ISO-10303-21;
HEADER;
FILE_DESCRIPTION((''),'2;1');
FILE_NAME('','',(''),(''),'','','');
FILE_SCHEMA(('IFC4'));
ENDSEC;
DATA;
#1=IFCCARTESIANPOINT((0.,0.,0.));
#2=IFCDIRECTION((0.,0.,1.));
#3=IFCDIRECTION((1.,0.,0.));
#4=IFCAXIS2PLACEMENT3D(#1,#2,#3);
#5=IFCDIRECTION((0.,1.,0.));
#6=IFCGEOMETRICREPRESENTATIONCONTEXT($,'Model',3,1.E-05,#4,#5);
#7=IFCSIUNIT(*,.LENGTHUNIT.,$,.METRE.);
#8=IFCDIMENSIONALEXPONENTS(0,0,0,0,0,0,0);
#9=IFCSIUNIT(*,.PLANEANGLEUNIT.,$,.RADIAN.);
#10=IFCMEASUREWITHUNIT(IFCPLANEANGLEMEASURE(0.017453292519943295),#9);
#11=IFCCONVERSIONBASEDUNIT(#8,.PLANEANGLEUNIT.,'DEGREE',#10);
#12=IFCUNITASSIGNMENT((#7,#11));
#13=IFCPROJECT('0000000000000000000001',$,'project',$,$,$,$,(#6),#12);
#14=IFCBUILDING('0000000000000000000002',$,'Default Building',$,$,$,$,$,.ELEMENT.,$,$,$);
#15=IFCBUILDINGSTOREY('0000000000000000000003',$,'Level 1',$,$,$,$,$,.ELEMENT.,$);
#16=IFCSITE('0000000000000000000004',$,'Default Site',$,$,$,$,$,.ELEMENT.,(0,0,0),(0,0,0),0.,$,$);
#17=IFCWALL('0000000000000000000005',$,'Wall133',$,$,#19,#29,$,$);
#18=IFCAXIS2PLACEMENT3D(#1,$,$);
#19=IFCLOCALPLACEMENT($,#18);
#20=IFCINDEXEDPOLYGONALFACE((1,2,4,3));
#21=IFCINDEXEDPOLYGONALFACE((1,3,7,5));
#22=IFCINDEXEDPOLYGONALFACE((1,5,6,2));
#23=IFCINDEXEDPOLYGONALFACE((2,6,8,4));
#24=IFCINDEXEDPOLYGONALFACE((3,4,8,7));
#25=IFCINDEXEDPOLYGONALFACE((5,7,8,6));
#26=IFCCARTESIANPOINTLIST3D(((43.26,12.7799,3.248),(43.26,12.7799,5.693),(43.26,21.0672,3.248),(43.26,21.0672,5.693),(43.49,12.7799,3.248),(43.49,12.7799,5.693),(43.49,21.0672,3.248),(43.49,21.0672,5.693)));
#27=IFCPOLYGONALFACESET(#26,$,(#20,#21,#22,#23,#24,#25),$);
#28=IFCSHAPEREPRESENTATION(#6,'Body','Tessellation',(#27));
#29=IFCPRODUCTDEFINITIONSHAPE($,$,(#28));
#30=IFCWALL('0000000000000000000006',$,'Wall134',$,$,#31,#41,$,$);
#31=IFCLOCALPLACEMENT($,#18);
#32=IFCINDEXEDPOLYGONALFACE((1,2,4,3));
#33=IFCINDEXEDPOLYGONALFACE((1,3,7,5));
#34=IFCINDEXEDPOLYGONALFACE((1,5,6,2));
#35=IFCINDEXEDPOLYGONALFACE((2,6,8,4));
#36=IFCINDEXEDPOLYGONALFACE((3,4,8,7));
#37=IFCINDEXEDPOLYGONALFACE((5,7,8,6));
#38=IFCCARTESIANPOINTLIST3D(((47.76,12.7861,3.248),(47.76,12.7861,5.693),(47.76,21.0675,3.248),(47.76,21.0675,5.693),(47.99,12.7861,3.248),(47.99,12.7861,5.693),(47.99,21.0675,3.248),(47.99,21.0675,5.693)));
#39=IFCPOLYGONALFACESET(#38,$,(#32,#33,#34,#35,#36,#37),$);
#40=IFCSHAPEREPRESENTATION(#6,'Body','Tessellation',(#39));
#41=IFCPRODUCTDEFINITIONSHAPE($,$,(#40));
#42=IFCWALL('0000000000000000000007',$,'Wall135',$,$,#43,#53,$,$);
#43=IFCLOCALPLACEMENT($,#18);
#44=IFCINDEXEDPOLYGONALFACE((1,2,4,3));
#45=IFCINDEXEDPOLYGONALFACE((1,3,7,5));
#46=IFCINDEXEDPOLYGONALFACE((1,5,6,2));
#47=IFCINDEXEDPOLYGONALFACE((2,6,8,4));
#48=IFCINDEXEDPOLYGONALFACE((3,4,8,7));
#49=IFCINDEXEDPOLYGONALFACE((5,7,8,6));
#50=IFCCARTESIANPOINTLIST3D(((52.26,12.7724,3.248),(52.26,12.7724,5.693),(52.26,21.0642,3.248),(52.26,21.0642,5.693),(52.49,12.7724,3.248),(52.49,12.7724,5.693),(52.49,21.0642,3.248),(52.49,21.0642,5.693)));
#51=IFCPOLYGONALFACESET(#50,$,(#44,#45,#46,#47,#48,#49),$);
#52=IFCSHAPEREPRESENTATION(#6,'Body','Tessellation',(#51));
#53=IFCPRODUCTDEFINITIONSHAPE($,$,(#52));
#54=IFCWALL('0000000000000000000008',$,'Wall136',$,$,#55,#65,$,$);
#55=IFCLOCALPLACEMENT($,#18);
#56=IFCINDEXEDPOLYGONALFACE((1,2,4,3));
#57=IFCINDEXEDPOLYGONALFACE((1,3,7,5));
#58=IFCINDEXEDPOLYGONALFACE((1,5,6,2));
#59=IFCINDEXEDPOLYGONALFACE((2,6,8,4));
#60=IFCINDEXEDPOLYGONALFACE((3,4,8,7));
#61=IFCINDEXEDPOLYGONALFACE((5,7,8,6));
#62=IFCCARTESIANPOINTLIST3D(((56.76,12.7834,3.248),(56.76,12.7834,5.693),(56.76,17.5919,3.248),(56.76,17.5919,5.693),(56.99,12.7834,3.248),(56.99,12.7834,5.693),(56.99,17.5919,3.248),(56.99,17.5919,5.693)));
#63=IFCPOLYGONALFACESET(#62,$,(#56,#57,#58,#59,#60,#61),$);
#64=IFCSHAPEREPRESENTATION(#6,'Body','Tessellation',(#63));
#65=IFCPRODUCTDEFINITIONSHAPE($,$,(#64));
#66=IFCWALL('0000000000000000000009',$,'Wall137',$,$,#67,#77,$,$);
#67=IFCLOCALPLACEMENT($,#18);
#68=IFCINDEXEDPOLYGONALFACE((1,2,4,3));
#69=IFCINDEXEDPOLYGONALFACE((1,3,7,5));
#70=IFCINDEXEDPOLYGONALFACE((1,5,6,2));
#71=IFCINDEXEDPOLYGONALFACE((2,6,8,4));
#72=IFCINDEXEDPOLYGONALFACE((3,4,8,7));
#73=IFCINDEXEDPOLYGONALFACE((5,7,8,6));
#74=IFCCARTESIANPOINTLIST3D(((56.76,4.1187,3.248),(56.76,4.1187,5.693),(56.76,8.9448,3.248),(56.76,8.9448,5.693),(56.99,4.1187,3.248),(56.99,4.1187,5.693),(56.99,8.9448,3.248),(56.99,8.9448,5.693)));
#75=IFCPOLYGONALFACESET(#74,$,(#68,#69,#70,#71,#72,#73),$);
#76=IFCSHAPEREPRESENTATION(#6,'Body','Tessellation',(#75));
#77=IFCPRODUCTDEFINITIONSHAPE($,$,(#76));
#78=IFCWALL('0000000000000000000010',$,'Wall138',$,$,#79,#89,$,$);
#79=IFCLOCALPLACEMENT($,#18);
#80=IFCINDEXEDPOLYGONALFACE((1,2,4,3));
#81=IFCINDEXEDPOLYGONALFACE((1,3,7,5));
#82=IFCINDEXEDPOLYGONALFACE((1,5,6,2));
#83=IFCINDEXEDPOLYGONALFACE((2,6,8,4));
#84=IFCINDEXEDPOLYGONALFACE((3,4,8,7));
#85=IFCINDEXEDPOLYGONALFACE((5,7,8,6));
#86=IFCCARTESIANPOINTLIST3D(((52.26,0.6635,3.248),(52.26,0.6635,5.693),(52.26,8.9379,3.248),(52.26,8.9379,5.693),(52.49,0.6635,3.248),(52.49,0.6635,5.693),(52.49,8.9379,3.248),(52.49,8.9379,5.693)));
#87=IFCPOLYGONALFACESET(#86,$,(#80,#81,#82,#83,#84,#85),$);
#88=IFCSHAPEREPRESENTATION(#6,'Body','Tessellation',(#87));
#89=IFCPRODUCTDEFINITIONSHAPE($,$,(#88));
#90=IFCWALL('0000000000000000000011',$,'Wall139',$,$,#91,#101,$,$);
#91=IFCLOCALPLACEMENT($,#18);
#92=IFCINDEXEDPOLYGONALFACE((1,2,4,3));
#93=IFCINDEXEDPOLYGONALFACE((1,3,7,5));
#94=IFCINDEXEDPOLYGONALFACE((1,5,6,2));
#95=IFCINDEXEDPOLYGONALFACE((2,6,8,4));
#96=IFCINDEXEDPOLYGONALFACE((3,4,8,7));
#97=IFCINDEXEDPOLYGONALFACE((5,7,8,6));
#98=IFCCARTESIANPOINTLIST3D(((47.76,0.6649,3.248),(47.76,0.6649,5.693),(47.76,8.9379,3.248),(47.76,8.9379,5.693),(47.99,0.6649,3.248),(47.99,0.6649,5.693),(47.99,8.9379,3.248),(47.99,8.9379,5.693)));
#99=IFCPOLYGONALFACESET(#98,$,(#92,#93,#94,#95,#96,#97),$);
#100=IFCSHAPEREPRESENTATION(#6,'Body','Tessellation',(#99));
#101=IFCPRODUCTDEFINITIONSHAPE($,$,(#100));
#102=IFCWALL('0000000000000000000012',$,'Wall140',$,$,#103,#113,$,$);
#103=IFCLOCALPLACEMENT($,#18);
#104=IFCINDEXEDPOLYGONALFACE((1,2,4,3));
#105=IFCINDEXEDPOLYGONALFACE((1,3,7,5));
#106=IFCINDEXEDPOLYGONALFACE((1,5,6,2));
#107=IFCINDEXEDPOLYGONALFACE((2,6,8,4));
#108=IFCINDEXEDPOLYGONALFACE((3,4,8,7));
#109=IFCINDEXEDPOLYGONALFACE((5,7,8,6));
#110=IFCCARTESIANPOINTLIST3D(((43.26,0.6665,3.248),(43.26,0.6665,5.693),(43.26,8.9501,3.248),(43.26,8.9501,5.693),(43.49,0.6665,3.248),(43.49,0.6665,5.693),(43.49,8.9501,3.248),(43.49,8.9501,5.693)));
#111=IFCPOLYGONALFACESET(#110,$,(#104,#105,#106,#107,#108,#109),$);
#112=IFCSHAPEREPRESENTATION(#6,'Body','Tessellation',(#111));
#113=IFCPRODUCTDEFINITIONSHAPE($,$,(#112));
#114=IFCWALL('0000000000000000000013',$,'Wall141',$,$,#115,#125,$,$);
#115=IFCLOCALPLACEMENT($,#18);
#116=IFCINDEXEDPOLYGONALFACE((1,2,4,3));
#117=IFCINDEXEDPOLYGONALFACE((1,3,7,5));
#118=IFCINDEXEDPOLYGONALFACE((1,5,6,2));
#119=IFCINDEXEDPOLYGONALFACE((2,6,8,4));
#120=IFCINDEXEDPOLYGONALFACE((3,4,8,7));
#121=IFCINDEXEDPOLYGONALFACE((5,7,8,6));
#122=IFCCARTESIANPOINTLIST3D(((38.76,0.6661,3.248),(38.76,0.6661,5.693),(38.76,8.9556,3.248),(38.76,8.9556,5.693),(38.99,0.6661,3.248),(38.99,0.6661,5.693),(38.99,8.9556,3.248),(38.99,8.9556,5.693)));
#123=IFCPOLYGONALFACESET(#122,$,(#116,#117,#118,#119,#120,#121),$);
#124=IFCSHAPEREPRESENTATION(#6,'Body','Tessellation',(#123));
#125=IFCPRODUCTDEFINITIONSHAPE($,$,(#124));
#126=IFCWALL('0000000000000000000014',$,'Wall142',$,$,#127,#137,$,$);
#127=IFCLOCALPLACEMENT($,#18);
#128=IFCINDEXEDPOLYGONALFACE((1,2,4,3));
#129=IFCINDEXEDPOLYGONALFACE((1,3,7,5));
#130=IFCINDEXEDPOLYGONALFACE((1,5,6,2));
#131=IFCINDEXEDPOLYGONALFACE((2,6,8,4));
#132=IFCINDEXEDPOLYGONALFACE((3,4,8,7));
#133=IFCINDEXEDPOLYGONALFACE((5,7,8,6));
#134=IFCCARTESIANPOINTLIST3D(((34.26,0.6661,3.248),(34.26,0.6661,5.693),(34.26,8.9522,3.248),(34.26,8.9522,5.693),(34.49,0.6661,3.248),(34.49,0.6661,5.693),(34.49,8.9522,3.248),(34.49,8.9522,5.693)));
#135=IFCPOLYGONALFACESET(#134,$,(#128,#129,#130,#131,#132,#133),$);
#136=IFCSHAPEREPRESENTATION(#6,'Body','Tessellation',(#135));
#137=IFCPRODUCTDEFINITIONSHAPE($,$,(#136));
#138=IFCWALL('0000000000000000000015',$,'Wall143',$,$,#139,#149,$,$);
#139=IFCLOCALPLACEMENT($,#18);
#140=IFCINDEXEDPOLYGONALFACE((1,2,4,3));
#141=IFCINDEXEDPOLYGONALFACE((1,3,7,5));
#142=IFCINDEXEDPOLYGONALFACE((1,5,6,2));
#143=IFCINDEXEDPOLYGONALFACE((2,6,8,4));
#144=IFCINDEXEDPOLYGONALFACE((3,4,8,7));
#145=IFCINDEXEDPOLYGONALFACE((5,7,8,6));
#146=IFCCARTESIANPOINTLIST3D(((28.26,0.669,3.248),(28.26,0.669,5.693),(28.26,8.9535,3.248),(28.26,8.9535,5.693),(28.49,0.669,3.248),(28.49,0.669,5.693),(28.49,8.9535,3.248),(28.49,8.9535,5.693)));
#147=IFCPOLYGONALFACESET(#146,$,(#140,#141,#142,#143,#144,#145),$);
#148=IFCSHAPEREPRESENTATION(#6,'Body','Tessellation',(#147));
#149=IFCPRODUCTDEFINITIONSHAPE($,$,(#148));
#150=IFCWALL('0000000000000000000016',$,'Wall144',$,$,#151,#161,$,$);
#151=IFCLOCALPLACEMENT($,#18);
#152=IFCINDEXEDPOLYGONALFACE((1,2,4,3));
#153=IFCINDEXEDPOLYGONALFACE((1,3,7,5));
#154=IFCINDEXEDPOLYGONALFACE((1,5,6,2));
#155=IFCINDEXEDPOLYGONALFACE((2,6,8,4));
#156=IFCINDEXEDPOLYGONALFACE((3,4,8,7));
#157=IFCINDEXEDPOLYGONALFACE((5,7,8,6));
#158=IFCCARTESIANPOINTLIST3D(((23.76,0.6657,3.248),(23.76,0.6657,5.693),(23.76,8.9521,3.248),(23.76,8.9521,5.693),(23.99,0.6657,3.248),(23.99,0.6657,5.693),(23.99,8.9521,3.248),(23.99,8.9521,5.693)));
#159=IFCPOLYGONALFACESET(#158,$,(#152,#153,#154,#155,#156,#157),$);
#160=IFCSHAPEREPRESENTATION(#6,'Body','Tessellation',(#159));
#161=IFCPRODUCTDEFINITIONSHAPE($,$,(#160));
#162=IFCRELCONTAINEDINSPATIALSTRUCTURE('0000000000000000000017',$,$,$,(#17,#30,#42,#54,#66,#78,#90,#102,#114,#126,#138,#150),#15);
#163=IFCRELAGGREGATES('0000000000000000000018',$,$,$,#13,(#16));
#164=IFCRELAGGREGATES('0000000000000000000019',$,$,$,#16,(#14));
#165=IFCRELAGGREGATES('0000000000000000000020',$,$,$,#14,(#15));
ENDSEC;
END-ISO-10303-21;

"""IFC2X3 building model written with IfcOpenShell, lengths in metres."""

from ifc_helpers import new_model, entity, si_unit, converted_unit, direction, frame, frame_2d, origin_with_axes, place, context, project, spatial, rectangle, extrude, element, save


model = new_model("IFC2X3")

# Units and contexts
model_context = context("Model", 3, precision=1e-05, world=origin_with_axes(), true_north=direction((0.0, 1.0, 0.0)))
ifc_project = project(units=[si_unit("LENGTHUNIT", "METRE"), converted_unit("PLANEANGLEUNIT", "DEGREE", entity("IfcPlaneAngleMeasure", 0.017453292519943295), si_unit("PLANEANGLEUNIT", "RADIAN"), dimensions=[0, 0, 0, 0, 0, 0, 0])], contexts=[model_context])

# Site, building, storey
site = spatial("IfcSite", under=ifc_project, Name="Default Site", CompositionType="ELEMENT", RefLatitude=(0, 0, 0), RefLongitude=(0, 0, 0), RefElevation=0.0)
building = spatial("IfcBuilding", under=site, Name="Default Building", CompositionType="ELEMENT")
storey = spatial("IfcBuildingStorey", under=building, Name="Level 1", CompositionType="ELEMENT")

# Shared definitions
placement = place(None, origin_with_axes())

# Walls
element("IfcWall", 1, at=placement, inside=storey, Name="Wall133", context=model_context, shape_type="SweptSolid", body=[
    extrude(rectangle(XDim=8.2873, YDim=0.23, at=frame_2d((0.0, 0.0), x_axis=(0.0, 1.0, 0.0))), frame((43.375, 16.9235, 3.248), z_axis=(0.0, 0.0, 1.0), x_axis=(1.0, 0.0, 0.0)), (0.0, 0.0, 1.0), 2.445),
])
element("IfcWall", 2, at=placement, inside=storey, Name="Wall134", context=model_context, shape_type="SweptSolid", body=[
    extrude(rectangle(XDim=8.2814, YDim=0.23, at=frame_2d((0.0, 0.0), x_axis=(0.0, -1.0, 0.0))), frame((47.875, 16.9268, 3.248), z_axis=(0.0, 0.0, 1.0), x_axis=(1.0, 0.0, 0.0)), (0.0, 0.0, 1.0), 2.445),
])
element("IfcWall", 3, at=placement, inside=storey, Name="Wall135", context=model_context, shape_type="SweptSolid", body=[
    extrude(rectangle(XDim=8.2918, YDim=0.23, at=frame_2d((0.0, 0.0), x_axis=(0.0, -1.0, 0.0))), frame((52.375, 16.9183, 3.248), z_axis=(0.0, 0.0, 1.0), x_axis=(1.0, 0.0, 0.0)), (0.0, 0.0, 1.0), 2.445),
])
element("IfcWall", 4, at=placement, inside=storey, Name="Wall136", context=model_context, shape_type="SweptSolid", body=[
    extrude(rectangle(XDim=4.8085, YDim=0.23, at=frame_2d((0.0, 0.0), x_axis=(0.0, 1.0, 0.0))), frame((56.875, 15.1877, 3.248), z_axis=(0.0, 0.0, 1.0), x_axis=(1.0, 0.0, 0.0)), (0.0, 0.0, 1.0), 2.445),
])
element("IfcWall", 5, at=placement, inside=storey, Name="Wall137", context=model_context, shape_type="SweptSolid", body=[
    extrude(rectangle(XDim=4.8261, YDim=0.23, at=frame_2d((0.0, 0.0), x_axis=(0.0, -1.0, 0.0))), frame((56.875, 6.5318, 3.248), z_axis=(0.0, 0.0, 1.0), x_axis=(1.0, 0.0, 0.0)), (0.0, 0.0, 1.0), 2.445),
])
element("IfcWall", 6, at=placement, inside=storey, Name="Wall138", context=model_context, shape_type="SweptSolid", body=[
    extrude(rectangle(XDim=8.2744, YDim=0.23, at=frame_2d((0.0, 0.0), x_axis=(0.0, 1.0, 0.0))), frame((52.375, 4.8007, 3.248), z_axis=(0.0, 0.0, 1.0), x_axis=(1.0, 0.0, 0.0)), (0.0, 0.0, 1.0), 2.445),
])
element("IfcWall", 7, at=placement, inside=storey, Name="Wall139", context=model_context, shape_type="SweptSolid", body=[
    extrude(rectangle(XDim=8.273, YDim=0.23, at=frame_2d((0.0, 0.0), x_axis=(0.0, -1.0, 0.0))), frame((47.875, 4.8014, 3.248), z_axis=(0.0, 0.0, 1.0), x_axis=(1.0, 0.0, 0.0)), (0.0, 0.0, 1.0), 2.445),
])
element("IfcWall", 8, at=placement, inside=storey, Name="Wall140", context=model_context, shape_type="SweptSolid", body=[
    extrude(rectangle(XDim=8.2836, YDim=0.23, at=frame_2d((0.0, 0.0), x_axis=(0.0, 1.0, 0.0))), frame((43.375, 4.8083, 3.248), z_axis=(0.0, 0.0, 1.0), x_axis=(1.0, 0.0, 0.0)), (0.0, 0.0, 1.0), 2.445),
])
element("IfcWall", 9, at=placement, inside=storey, Name="Wall141", context=model_context, shape_type="SweptSolid", body=[
    extrude(rectangle(XDim=8.2895, YDim=0.23, at=frame_2d((0.0, 0.0), x_axis=(0.0, -1.0, 0.0))), frame((38.875, 4.8109, 3.248), z_axis=(0.0, 0.0, 1.0), x_axis=(1.0, 0.0, 0.0)), (0.0, 0.0, 1.0), 2.445),
])
element("IfcWall", 10, at=placement, inside=storey, Name="Wall142", context=model_context, shape_type="SweptSolid", body=[
    extrude(rectangle(XDim=8.2861, YDim=0.23, at=frame_2d((0.0, 0.0), x_axis=(0.0, -1.0, 0.0))), frame((34.375, 4.8092, 3.248), z_axis=(0.0, 0.0, 1.0), x_axis=(1.0, 0.0, 0.0)), (0.0, 0.0, 1.0), 2.445),
])
element("IfcWall", 11, at=placement, inside=storey, Name="Wall143", context=model_context, shape_type="SweptSolid", body=[
    extrude(rectangle(XDim=8.2845, YDim=0.23, at=frame_2d((0.0, 0.0), x_axis=(0.0, 1.0, 0.0))), frame((28.375, 4.8113, 3.248), z_axis=(0.0, 0.0, 1.0), x_axis=(1.0, 0.0, 0.0)), (0.0, 0.0, 1.0), 2.445),
])
element("IfcWall", 12, at=placement, inside=storey, Name="Wall144", context=model_context, shape_type="SweptSolid", body=[
    extrude(rectangle(XDim=8.2865, YDim=0.23, at=frame_2d((0.0, 0.0), x_axis=(0.0, -1.0, 0.0))), frame((23.875, 4.8089, 3.248), z_axis=(0.0, 0.0, 1.0), x_axis=(1.0, 0.0, 0.0)), (0.0, 0.0, 1.0), 2.445),
])

save(model, "model.ifc")
